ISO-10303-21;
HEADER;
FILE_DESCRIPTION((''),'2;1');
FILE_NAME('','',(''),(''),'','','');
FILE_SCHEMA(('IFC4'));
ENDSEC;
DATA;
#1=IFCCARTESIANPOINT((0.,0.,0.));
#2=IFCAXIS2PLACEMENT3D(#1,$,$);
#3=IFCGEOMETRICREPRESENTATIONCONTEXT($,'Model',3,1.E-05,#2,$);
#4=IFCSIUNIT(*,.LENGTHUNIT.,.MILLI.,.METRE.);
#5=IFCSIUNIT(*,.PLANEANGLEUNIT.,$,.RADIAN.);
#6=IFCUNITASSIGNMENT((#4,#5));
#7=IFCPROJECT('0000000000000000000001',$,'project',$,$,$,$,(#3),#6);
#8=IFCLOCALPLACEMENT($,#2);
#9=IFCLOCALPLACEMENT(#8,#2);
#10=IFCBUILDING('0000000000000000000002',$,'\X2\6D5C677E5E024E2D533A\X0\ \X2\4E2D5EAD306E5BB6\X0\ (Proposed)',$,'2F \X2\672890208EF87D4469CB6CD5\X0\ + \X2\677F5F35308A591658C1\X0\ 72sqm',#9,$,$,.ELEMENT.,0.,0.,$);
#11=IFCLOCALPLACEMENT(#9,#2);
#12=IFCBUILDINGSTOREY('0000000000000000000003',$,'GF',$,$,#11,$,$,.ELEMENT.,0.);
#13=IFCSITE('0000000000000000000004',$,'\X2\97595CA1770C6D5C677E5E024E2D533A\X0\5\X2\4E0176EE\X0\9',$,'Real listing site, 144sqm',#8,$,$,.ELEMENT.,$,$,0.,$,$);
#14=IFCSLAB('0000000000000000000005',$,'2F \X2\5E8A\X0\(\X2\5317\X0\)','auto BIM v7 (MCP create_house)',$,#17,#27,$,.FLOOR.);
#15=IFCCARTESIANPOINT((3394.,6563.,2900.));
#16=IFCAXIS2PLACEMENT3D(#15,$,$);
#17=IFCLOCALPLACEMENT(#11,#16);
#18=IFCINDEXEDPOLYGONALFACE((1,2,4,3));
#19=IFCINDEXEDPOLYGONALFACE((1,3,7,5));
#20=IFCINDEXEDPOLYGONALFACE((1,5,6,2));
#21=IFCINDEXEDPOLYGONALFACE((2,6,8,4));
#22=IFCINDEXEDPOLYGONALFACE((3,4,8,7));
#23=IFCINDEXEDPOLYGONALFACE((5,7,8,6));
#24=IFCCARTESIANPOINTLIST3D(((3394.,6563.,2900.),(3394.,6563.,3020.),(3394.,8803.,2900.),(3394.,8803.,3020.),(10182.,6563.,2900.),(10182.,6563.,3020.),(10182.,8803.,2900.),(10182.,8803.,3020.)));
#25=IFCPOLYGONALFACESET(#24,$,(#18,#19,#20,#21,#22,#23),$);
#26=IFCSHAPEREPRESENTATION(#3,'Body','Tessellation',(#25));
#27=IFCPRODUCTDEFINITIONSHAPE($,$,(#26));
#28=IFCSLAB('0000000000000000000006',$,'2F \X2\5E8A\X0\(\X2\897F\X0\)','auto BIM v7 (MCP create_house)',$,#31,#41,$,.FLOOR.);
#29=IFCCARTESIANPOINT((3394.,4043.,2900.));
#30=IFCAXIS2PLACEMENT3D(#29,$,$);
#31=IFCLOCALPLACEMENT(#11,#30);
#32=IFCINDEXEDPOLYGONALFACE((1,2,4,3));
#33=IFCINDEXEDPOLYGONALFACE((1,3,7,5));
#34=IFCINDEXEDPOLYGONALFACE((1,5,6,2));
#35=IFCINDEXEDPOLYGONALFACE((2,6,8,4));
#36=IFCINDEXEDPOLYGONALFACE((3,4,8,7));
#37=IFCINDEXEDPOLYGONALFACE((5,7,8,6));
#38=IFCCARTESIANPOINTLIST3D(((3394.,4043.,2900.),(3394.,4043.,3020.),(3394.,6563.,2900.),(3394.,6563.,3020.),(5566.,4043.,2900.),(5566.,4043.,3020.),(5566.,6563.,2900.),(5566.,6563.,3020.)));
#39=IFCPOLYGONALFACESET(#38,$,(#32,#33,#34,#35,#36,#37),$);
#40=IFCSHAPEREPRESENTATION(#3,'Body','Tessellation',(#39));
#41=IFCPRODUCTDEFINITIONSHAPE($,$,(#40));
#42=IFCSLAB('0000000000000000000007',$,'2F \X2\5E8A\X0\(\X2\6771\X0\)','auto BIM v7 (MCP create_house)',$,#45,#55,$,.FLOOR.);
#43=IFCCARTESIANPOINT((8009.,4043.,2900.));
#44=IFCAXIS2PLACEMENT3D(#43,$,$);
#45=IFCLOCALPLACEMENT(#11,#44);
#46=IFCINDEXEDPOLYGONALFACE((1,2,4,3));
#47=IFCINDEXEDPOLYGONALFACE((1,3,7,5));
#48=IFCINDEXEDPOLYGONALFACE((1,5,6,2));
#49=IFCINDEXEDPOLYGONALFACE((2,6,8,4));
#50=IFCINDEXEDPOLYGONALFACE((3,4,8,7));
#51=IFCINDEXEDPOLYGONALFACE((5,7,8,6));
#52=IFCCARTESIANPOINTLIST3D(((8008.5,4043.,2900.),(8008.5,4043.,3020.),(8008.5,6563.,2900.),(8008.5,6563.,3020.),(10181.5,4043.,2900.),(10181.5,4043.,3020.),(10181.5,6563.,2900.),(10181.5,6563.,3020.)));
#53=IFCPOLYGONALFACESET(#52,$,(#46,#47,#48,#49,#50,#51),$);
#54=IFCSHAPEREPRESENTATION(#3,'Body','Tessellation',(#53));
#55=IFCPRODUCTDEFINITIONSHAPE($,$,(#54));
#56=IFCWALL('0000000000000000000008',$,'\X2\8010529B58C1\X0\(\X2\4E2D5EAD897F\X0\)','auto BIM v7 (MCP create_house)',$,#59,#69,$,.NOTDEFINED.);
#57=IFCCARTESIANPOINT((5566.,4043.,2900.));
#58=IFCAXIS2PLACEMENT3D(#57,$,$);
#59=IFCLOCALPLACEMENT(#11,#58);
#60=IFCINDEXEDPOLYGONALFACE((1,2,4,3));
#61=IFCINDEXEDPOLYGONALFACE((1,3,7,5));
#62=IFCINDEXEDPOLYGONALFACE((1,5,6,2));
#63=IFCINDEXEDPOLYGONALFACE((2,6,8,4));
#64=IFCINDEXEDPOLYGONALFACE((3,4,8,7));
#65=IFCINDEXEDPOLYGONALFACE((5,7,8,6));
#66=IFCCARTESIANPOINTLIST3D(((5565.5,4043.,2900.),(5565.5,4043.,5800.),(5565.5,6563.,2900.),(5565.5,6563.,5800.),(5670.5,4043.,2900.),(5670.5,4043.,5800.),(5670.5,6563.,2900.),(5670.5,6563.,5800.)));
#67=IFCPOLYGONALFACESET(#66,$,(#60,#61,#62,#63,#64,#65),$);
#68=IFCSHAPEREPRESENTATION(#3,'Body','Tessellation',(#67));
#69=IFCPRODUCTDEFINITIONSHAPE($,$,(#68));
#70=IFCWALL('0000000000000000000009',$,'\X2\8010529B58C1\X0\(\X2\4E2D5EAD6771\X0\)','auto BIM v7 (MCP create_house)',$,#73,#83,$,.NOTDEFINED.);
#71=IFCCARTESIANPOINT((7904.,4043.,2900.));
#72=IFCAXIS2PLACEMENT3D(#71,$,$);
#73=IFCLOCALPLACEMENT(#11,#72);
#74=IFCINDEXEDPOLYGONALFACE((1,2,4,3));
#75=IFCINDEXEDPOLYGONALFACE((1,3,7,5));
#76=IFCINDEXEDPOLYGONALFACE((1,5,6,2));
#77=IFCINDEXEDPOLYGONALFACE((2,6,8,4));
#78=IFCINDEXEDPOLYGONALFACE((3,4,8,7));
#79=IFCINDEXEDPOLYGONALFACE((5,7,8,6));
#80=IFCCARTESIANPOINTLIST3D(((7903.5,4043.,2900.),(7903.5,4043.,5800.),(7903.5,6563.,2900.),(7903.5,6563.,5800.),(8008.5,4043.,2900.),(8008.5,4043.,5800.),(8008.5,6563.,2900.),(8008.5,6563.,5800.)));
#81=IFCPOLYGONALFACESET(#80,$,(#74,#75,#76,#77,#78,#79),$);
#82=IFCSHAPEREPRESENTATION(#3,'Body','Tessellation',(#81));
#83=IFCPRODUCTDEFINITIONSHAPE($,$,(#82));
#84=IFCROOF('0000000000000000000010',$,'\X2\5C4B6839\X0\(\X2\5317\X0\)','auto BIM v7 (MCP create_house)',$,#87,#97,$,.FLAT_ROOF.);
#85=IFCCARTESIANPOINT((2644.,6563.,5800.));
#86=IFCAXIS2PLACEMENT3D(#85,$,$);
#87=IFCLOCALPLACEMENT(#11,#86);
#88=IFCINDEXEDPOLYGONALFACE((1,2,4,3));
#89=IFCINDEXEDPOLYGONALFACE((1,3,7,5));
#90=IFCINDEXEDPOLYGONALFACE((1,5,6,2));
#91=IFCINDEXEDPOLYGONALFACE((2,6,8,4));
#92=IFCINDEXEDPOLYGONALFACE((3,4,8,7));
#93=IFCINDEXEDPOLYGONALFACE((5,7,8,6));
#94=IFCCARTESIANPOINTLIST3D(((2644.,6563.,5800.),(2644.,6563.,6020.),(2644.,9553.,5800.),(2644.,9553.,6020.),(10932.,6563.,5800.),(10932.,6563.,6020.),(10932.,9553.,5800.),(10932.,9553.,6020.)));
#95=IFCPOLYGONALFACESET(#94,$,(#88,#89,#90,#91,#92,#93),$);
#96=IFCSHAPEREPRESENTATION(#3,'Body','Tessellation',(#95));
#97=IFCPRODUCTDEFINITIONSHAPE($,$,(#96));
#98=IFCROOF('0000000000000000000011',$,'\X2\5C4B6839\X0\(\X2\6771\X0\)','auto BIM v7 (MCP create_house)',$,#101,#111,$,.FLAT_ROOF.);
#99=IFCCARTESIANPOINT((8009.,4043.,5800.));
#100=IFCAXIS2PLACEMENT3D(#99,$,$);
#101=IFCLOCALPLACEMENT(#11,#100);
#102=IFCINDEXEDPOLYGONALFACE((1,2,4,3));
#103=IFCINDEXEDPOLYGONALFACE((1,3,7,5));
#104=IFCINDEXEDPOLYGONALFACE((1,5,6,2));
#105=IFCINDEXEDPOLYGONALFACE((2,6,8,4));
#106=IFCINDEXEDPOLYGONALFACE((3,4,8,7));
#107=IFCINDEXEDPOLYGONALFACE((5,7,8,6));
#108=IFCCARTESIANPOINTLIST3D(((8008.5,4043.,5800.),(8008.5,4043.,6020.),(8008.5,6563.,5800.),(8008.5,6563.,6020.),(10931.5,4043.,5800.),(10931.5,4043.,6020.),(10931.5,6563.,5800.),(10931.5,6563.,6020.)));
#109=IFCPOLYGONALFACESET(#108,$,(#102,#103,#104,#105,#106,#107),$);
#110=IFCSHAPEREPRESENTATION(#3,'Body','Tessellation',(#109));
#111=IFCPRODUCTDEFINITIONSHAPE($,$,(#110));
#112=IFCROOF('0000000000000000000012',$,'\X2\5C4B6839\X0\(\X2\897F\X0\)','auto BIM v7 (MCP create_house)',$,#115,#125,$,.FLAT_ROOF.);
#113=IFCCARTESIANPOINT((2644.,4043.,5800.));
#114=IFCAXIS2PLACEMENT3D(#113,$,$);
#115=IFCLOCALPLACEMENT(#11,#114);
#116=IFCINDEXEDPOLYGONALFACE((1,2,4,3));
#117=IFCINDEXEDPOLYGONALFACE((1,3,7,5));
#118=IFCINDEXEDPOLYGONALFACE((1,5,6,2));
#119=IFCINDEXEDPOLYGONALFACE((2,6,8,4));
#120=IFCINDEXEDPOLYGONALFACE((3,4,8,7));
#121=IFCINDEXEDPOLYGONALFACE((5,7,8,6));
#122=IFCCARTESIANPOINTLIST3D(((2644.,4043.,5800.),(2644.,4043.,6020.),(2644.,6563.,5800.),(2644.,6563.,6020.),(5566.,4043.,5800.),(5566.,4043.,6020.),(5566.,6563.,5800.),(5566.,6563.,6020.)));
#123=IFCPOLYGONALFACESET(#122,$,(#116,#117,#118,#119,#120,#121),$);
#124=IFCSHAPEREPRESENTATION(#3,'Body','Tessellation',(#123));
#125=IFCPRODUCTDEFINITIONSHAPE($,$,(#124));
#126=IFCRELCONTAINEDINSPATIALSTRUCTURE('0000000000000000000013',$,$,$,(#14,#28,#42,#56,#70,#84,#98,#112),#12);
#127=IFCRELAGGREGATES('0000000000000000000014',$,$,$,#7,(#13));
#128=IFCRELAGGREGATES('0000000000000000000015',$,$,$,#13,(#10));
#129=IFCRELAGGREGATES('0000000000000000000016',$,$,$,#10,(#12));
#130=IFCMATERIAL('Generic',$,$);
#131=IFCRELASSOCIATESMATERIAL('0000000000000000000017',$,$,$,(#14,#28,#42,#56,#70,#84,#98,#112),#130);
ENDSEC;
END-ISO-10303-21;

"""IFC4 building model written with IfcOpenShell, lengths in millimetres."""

from ifc_helpers import new_model, si_unit, frame, frame_2d, origin, place, context, project, spatial, rectangle, extrude, material, element, save


model = new_model("IFC4")

# Units and contexts
model_context = context("Model", 3, precision=1e-05, world=origin())
ifc_project = project(units=[si_unit("LENGTHUNIT", "METRE", prefix="MILLI"), si_unit("PLANEANGLEUNIT", "RADIAN")], contexts=[model_context])

# Site, building, storey
site_placement = place(None, origin())
site = spatial("IfcSite", under=ifc_project, at=site_placement, Name="静岡県浜松市中区5丁目9", ObjectType="Real listing site, 144sqm", CompositionType="ELEMENT", RefElevation=0.0)
building_placement = place(site_placement, origin())
building = spatial("IfcBuilding", under=site, at=building_placement, Name="浜松市中区 中庭の家 (Proposed)", ObjectType="2F 木造軸組構法 + 板張り外壁 72sqm", CompositionType="ELEMENT", ElevationOfRefHeight=0.0, ElevationOfTerrain=0.0)
storey_placement = place(building_placement, origin())
storey = spatial("IfcBuildingStorey", under=building, at=storey_placement, Name="GF", CompositionType="ELEMENT", Elevation=0.0)

# Slabs
ifc_material = material(Name="Generic")
slab_1_placement = place(storey_placement, frame((3394.0, 6563.0, 2900.0)))
element("IfcSlab", 1, at=slab_1_placement, inside=storey, material=ifc_material, Name="2F 床(北)", Description="auto BIM v7 (MCP create_house)", PredefinedType="FLOOR", context=model_context, shape_type="SweptSolid", body=[
    extrude(rectangle(XDim=6788.0, YDim=2240.0, at=frame_2d((3394.0, 1120.0))), frame((3394.0, 6563.0, 2900.0)), (0.0, 0.0, 1.0), 120.0),
])
slab_2_placement = place(storey_placement, frame((3394.0, 4043.0, 2900.0)))
element("IfcSlab", 2, at=slab_2_placement, inside=storey, material=ifc_material, Name="2F 床(西)", Description="auto BIM v7 (MCP create_house)", PredefinedType="FLOOR", context=model_context, shape_type="SweptSolid", body=[
    extrude(rectangle(XDim=2172.0, YDim=2520.0, at=frame_2d((1086.0, 1260.0))), frame((3394.0, 4043.0, 2900.0)), (0.0, 0.0, 1.0), 120.0),
])
slab_3_placement = place(storey_placement, frame((8009.0, 4043.0, 2900.0)))
element("IfcSlab", 3, at=slab_3_placement, inside=storey, material=ifc_material, Name="2F 床(東)", Description="auto BIM v7 (MCP create_house)", PredefinedType="FLOOR", context=model_context, shape_type="SweptSolid", body=[
    extrude(rectangle(XDim=2173.0, YDim=2520.0, at=frame_2d((1086.0, 1260.0))), frame((8009.0, 4043.0, 2900.0)), (0.0, 0.0, 1.0), 120.0),
])

# Walls
wall_1_placement = place(storey_placement, frame((5566.0, 4043.0, 2900.0)))
element("IfcWall", 4, at=wall_1_placement, inside=storey, material=ifc_material, Name="耐力壁(中庭西)", Description="auto BIM v7 (MCP create_house)", PredefinedType="NOTDEFINED", context=model_context, shape_type="SweptSolid", body=[
    extrude(rectangle(XDim=105.0, YDim=2520.0, at=frame_2d((52.0, 1260.0))), frame((5566.0, 4043.0, 2900.0)), (0.0, 0.0, 1.0), 2900.0),
])
wall_2_placement = place(storey_placement, frame((7904.0, 4043.0, 2900.0)))
element("IfcWall", 5, at=wall_2_placement, inside=storey, material=ifc_material, Name="耐力壁(中庭東)", Description="auto BIM v7 (MCP create_house)", PredefinedType="NOTDEFINED", context=model_context, shape_type="SweptSolid", body=[
    extrude(rectangle(XDim=105.0, YDim=2520.0, at=frame_2d((52.0, 1260.0))), frame((7904.0, 4043.0, 2900.0)), (0.0, 0.0, 1.0), 2900.0),
])

# Roofs
roof_1_placement = place(storey_placement, frame((2644.0, 6563.0, 5800.0)))
element("IfcRoof", 6, at=roof_1_placement, inside=storey, material=ifc_material, Name="屋根(北)", Description="auto BIM v7 (MCP create_house)", PredefinedType="FLAT_ROOF", context=model_context, shape_type="SweptSolid", body=[
    extrude(rectangle(XDim=8288.0, YDim=2990.0, at=frame_2d((4144.0, 1495.0))), frame((2644.0, 6563.0, 5800.0)), (0.0, 0.0, 1.0), 220.0),
])
roof_2_placement = place(storey_placement, frame((8009.0, 4043.0, 5800.0)))
element("IfcRoof", 7, at=roof_2_placement, inside=storey, material=ifc_material, Name="屋根(東)", Description="auto BIM v7 (MCP create_house)", PredefinedType="FLAT_ROOF", context=model_context, shape_type="SweptSolid", body=[
    extrude(rectangle(XDim=2923.0, YDim=2520.0, at=frame_2d((1461.0, 1260.0))), frame((8009.0, 4043.0, 5800.0)), (0.0, 0.0, 1.0), 220.0),
])
roof_3_placement = place(storey_placement, frame((2644.0, 4043.0, 5800.0)))
element("IfcRoof", 8, at=roof_3_placement, inside=storey, material=ifc_material, Name="屋根(西)", Description="auto BIM v7 (MCP create_house)", PredefinedType="FLAT_ROOF", context=model_context, shape_type="SweptSolid", body=[
    extrude(rectangle(XDim=2922.0, YDim=2520.0, at=frame_2d((1461.0, 1260.0))), frame((2644.0, 4043.0, 5800.0)), (0.0, 0.0, 1.0), 220.0),
])

save(model, "model.ifc")
